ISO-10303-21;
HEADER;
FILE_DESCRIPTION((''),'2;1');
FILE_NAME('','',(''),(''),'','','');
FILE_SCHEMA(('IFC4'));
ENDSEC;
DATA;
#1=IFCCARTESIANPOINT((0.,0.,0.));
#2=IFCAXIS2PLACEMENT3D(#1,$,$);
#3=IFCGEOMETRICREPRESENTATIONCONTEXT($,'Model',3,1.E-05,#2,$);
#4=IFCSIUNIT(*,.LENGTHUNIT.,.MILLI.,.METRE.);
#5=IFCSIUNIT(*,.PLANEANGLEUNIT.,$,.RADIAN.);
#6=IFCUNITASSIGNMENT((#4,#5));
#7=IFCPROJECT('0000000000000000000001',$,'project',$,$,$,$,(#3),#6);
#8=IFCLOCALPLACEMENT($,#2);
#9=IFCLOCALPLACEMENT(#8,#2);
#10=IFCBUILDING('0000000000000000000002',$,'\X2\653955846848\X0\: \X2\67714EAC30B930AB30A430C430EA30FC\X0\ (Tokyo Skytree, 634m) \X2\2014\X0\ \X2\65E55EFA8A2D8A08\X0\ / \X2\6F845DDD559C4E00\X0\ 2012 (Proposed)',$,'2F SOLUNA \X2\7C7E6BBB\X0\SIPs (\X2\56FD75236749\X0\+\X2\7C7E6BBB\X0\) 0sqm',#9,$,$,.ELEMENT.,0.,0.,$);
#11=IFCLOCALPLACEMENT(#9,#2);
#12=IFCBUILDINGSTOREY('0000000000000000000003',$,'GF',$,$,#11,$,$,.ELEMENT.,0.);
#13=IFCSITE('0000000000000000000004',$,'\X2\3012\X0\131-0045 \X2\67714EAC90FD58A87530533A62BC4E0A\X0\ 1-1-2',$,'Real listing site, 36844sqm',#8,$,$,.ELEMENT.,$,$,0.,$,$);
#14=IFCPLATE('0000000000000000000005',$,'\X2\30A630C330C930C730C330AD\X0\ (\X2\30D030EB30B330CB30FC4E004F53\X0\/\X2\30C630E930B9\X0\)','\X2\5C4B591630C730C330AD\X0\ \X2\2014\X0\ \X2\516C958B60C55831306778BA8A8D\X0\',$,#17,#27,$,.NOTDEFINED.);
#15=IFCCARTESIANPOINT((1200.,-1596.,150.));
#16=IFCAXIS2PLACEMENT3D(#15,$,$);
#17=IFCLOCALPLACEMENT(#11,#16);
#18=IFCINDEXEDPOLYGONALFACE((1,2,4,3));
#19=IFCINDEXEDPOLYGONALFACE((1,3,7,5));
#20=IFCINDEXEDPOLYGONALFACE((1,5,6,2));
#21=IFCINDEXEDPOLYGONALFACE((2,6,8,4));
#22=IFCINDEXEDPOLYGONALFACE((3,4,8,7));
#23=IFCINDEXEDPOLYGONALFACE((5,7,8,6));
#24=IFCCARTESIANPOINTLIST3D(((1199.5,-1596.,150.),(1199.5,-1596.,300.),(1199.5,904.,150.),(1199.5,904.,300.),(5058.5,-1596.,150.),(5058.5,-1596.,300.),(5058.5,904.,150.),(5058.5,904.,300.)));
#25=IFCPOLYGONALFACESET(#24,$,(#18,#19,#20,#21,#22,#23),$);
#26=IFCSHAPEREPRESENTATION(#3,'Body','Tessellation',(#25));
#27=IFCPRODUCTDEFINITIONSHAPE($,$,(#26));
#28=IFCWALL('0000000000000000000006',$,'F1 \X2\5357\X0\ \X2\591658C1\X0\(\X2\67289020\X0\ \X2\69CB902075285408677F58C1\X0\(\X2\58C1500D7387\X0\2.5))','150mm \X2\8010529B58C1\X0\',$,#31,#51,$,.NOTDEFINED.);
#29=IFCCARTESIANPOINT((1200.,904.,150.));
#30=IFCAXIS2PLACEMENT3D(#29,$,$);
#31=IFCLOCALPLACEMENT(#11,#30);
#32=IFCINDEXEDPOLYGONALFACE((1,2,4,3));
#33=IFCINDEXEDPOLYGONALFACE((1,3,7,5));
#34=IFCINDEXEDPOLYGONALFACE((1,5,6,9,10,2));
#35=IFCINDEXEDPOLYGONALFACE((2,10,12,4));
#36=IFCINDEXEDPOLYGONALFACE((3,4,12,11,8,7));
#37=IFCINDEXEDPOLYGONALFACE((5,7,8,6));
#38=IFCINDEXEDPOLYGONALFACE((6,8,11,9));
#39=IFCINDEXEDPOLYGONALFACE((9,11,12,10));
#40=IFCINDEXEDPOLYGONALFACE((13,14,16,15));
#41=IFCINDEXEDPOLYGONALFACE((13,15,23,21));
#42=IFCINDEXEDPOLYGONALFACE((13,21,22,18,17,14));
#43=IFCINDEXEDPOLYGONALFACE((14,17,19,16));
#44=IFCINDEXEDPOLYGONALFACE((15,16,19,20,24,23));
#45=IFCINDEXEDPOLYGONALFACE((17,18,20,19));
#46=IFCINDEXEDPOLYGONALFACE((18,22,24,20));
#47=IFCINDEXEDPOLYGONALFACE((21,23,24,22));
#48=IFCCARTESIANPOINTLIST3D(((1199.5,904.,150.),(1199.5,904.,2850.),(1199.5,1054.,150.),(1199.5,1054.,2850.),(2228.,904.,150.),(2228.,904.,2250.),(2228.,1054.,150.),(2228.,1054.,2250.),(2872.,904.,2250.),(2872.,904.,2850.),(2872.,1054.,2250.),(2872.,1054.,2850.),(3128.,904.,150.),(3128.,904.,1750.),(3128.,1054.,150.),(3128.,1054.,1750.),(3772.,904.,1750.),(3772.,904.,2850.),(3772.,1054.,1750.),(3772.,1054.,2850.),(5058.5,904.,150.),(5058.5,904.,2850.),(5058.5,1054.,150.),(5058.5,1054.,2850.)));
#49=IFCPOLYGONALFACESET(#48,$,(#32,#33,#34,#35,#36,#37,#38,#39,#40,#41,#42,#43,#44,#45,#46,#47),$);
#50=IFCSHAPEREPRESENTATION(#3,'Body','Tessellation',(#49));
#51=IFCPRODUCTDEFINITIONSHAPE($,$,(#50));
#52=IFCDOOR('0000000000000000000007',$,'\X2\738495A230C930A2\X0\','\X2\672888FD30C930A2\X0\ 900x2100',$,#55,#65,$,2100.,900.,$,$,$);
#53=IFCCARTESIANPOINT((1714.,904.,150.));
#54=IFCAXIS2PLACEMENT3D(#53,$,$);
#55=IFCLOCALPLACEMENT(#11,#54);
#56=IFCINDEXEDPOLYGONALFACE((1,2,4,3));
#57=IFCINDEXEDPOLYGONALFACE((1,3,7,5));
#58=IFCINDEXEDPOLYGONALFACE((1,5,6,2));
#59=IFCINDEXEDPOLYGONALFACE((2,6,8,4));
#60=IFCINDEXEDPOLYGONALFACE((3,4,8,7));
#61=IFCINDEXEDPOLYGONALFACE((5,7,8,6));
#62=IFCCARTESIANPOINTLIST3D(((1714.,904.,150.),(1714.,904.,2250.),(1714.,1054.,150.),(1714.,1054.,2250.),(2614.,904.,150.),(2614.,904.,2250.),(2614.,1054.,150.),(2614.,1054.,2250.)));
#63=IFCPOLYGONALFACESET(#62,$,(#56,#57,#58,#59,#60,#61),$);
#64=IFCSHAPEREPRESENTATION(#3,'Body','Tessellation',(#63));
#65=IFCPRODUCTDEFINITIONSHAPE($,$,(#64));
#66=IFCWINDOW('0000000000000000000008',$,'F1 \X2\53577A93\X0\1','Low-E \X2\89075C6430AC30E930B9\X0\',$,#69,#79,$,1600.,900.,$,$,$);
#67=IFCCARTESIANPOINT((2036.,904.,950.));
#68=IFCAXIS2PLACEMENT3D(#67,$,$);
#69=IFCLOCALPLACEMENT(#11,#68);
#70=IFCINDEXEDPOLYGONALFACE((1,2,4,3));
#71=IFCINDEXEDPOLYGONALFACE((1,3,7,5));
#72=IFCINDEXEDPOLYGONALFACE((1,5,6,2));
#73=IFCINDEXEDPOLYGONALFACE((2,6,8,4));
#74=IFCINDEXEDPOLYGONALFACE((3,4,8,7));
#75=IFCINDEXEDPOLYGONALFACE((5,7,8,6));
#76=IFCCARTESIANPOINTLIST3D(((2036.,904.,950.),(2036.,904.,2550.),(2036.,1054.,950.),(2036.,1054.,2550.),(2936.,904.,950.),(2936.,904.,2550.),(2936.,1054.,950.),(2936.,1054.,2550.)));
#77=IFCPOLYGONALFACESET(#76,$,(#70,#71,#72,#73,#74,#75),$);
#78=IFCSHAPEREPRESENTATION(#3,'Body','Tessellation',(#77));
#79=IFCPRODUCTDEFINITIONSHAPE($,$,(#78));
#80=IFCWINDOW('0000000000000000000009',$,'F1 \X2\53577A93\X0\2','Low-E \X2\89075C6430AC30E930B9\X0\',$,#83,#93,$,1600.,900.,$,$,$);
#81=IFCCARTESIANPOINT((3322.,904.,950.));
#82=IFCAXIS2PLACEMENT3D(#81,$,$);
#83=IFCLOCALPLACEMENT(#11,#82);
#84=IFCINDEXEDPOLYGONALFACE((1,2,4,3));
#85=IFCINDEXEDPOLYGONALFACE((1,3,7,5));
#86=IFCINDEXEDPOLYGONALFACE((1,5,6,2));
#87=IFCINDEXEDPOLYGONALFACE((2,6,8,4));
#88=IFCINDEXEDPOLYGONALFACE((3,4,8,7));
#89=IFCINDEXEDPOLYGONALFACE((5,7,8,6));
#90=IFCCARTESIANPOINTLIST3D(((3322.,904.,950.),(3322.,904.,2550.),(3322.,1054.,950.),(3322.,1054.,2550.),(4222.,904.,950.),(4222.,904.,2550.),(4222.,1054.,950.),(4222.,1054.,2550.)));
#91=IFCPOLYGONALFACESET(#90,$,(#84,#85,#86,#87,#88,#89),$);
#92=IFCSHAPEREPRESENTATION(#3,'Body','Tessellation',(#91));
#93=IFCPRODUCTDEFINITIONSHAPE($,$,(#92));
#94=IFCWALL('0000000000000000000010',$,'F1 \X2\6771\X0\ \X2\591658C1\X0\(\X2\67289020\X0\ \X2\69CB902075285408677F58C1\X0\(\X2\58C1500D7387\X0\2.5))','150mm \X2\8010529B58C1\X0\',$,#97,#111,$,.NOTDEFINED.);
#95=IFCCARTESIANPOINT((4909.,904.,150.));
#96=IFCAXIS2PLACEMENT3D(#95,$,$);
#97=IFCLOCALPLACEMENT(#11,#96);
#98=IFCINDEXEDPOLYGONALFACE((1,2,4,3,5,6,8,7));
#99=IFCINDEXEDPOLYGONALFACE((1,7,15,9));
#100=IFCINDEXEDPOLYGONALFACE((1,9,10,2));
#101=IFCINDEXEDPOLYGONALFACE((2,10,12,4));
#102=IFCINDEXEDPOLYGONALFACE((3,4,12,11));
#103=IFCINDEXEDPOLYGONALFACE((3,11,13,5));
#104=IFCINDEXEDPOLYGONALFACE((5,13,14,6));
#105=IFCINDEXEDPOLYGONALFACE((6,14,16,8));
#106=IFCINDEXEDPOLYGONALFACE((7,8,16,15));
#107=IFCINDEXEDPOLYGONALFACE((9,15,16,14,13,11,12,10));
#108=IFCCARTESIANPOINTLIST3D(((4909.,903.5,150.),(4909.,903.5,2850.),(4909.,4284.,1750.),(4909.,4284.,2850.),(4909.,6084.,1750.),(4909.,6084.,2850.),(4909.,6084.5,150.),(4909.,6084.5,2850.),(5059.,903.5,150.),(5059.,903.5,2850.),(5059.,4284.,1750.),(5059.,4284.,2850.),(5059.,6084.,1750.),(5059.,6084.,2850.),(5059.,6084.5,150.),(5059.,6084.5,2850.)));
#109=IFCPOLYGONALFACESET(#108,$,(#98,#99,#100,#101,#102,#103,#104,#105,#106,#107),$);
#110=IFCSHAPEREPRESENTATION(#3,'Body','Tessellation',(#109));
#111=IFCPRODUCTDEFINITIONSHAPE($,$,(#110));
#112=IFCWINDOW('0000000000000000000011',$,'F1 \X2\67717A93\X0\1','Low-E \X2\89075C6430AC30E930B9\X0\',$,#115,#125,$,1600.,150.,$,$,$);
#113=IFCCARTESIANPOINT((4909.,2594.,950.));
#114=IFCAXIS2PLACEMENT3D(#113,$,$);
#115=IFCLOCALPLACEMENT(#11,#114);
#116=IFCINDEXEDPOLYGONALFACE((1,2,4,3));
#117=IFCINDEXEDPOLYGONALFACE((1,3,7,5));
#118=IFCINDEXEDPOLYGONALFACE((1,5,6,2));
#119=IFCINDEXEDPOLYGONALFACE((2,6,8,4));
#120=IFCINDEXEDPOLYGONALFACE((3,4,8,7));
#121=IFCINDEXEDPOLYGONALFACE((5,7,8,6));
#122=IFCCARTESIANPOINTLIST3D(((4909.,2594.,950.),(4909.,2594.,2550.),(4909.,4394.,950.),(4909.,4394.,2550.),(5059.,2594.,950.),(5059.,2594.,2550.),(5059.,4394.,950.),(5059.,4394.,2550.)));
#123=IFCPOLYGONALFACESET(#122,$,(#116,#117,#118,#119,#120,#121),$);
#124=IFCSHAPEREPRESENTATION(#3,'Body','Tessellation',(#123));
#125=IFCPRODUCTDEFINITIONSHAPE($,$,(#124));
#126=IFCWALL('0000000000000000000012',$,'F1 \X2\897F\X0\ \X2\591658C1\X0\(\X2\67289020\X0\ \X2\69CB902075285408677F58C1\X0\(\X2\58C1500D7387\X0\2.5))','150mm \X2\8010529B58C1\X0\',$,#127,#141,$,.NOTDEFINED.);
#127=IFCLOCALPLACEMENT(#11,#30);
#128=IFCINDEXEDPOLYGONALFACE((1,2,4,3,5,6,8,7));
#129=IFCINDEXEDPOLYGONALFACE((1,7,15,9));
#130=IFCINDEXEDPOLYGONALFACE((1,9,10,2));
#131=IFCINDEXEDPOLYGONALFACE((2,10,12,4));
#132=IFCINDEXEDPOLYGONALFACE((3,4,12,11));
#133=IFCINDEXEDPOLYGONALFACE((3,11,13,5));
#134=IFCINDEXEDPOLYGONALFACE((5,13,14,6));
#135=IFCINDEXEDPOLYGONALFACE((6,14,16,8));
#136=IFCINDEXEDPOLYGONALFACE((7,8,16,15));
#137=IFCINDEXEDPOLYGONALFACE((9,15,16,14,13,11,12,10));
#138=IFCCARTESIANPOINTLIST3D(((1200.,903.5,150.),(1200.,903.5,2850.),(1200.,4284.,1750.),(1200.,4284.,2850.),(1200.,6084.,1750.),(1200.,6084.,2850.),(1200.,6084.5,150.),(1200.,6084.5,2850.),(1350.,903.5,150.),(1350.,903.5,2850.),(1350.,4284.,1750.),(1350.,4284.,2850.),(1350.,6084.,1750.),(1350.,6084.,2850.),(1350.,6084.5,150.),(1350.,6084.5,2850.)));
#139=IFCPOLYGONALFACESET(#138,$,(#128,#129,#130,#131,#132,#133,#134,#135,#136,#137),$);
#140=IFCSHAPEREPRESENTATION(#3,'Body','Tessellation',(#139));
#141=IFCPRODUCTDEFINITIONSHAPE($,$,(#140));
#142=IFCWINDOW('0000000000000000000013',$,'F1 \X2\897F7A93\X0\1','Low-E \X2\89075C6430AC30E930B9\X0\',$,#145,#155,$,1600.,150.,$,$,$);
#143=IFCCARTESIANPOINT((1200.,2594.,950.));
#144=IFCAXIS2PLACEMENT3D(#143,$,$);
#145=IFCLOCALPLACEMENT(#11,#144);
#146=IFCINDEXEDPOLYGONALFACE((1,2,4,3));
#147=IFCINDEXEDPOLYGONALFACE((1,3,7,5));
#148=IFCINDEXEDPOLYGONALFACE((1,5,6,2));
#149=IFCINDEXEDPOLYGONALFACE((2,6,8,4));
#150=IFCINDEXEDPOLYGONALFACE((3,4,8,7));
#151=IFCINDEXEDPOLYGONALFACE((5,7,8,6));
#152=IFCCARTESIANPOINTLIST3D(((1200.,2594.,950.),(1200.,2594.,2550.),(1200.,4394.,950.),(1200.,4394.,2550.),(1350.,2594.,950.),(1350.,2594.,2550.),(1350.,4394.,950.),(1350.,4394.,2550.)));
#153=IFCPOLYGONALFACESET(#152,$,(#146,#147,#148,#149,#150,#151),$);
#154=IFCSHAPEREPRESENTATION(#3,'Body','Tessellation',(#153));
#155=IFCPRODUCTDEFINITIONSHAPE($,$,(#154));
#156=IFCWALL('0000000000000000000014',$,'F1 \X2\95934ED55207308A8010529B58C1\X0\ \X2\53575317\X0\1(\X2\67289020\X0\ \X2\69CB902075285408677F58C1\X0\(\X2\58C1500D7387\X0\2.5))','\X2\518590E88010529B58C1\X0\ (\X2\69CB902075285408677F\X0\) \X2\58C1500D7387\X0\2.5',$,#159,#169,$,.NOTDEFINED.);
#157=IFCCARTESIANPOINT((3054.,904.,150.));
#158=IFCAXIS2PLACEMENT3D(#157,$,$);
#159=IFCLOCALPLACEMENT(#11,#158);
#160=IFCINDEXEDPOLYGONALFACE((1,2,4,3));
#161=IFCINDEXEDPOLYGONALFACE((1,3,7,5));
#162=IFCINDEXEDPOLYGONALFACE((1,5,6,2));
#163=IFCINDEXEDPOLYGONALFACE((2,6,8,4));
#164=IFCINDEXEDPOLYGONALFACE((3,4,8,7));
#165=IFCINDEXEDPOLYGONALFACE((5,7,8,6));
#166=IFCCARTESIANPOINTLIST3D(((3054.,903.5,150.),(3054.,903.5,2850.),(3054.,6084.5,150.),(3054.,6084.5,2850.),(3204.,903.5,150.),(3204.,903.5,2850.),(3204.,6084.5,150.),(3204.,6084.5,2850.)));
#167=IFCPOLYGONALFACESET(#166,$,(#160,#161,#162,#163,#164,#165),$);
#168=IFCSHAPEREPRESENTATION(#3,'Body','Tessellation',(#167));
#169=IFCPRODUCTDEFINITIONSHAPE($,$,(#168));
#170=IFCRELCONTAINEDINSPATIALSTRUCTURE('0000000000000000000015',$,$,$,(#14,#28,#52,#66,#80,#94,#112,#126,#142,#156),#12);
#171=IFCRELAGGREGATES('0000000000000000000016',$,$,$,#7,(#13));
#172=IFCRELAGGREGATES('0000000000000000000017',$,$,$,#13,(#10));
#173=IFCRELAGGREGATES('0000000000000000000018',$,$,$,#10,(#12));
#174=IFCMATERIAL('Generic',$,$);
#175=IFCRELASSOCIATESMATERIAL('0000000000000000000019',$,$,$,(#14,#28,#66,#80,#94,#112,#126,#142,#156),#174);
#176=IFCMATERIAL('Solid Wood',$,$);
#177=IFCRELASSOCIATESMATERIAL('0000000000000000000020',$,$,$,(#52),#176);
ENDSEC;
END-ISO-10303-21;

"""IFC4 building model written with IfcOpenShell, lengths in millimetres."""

from ifc_helpers import new_model, si_unit, frame, frame_2d, origin, place, context, project, spatial, rectangle, extrude, material, element, fill, save


model = new_model("IFC4")

# Units and contexts
model_context = context("Model", 3, precision=1e-05, world=origin())
ifc_project = project(units=[si_unit("LENGTHUNIT", "METRE", prefix="MILLI"), si_unit("PLANEANGLEUNIT", "RADIAN")], contexts=[model_context])

# Site, building, storey
site_placement = place(None, origin())
site = spatial("IfcSite", under=ifc_project, at=site_placement, Name="〒131-0045 東京都墨田区押上 1-1-2", ObjectType="Real listing site, 36844sqm", CompositionType="ELEMENT", RefElevation=0.0)
building_placement = place(site_placement, origin())
building = spatial("IfcBuilding", under=site, at=building_placement, Name="改善案: 東京スカイツリー (Tokyo Skytree, 634m) — 日建設計 / 澄川喜一 2012 (Proposed)", ObjectType="2F SOLUNA 籾殻SIPs (国産杉+籾殻) 0sqm", CompositionType="ELEMENT", ElevationOfRefHeight=0.0, ElevationOfTerrain=0.0)
storey_placement = place(building_placement, origin())
storey = spatial("IfcBuildingStorey", under=building, at=storey_placement, Name="GF", CompositionType="ELEMENT", Elevation=0.0)

# Shared definitions
ifc_material_1 = material(Name="Generic")

# Plate
plate_placement = place(storey_placement, frame((1200.0, -1596.0, 150.0)))
element("IfcPlate", 1, at=plate_placement, inside=storey, material=ifc_material_1, Name="ウッドデッキ (バルコニー一体/テラス)", Description="屋外デッキ — 公開情報で確認", PredefinedType="NOTDEFINED", context=model_context, shape_type="SweptSolid", body=[
    extrude(rectangle(XDim=3859.0, YDim=2500.0, at=frame_2d((1929.0, 1250.0))), frame((1200.0, -1596.0, 150.0)), (0.0, 0.0, 1.0), 150.0),
])

# Wall, openings, door, windows
wall_1_placement = place(storey_placement, frame((1200.0, 904.0, 150.0)))
wall_1 = element("IfcWall", 2, at=wall_1_placement, inside=storey, material=ifc_material_1, Name="F1 南 外壁(木造 構造用合板壁(壁倍率2.5))", Description="150mm 耐力壁", PredefinedType="NOTDEFINED", context=model_context, shape_type="SweptSolid", body=[
    extrude(rectangle(XDim=3859.0, YDim=150.0, at=frame_2d((1929.0, 75.0))), frame((1200.0, 904.0, 150.0)), (0.0, 0.0, 1.0), 2700.0),
])
opening_1_placement = place(storey_placement, frame((1714.0, 904.0, 150.0)))
opening_1 = element("IfcOpeningElement", 3, at=opening_1_placement, cuts=wall_1, PredefinedType="NOTDEFINED", context=model_context, shape_type="SweptSolid", body=[
    extrude(rectangle(XDim=900.0, YDim=150.0, at=frame_2d((450.0, 75.0))), frame((1714.0, 904.0, 150.0)), (0.0, 0.0, 1.0), 2100.0),
])
opening_2_placement = place(storey_placement, frame((2036.0, 904.0, 950.0)))
opening_2 = element("IfcOpeningElement", 4, at=opening_2_placement, cuts=wall_1, PredefinedType="NOTDEFINED", context=model_context, shape_type="SweptSolid", body=[
    extrude(rectangle(XDim=900.0, YDim=150.0, at=frame_2d((450.0, 75.0))), frame((2036.0, 904.0, 950.0)), (0.0, 0.0, 1.0), 1600.0),
])
opening_3_placement = place(storey_placement, frame((3322.0, 904.0, 950.0)))
opening_3 = element("IfcOpeningElement", 5, at=opening_3_placement, cuts=wall_1, PredefinedType="NOTDEFINED", context=model_context, shape_type="SweptSolid", body=[
    extrude(rectangle(XDim=900.0, YDim=150.0, at=frame_2d((450.0, 75.0))), frame((3322.0, 904.0, 950.0)), (0.0, 0.0, 1.0), 1600.0),
])
ifc_material_2 = material(Name="Solid Wood")
door_placement = place(storey_placement, frame((1714.0, 904.0, 150.0)))
door = element("IfcDoor", 6, at=door_placement, inside=storey, material=ifc_material_2, Name="玄関ドア", Description="木製ドア 900x2100", OverallHeight=2100.0, OverallWidth=900.0, context=model_context, shape_type="SweptSolid", body=[
    extrude(rectangle(XDim=900.0, YDim=150.0, at=frame_2d((450.0, 75.0))), frame((1714.0, 904.0, 150.0)), (0.0, 0.0, 1.0), 2100.0),
])
fill(opening_1, door)
window_1_placement = place(storey_placement, frame((2036.0, 904.0, 950.0)))
window_1 = element("IfcWindow", 7, at=window_1_placement, inside=storey, material=ifc_material_1, Name="F1 南窓1", Description="Low-E 複層ガラス", OverallHeight=1600.0, OverallWidth=900.0, context=model_context, shape_type="SweptSolid", body=[
    extrude(rectangle(XDim=900.0, YDim=150.0, at=frame_2d((450.0, 75.0))), frame((2036.0, 904.0, 950.0)), (0.0, 0.0, 1.0), 1600.0),
])
fill(opening_2, window_1)
window_2_placement = place(storey_placement, frame((3322.0, 904.0, 950.0)))
window_2 = element("IfcWindow", 8, at=window_2_placement, inside=storey, material=ifc_material_1, Name="F1 南窓2", Description="Low-E 複層ガラス", OverallHeight=1600.0, OverallWidth=900.0, context=model_context, shape_type="SweptSolid", body=[
    extrude(rectangle(XDim=900.0, YDim=150.0, at=frame_2d((450.0, 75.0))), frame((3322.0, 904.0, 950.0)), (0.0, 0.0, 1.0), 1600.0),
])
fill(opening_3, window_2)

# Walls, openings, windows
wall_2_placement = place(storey_placement, frame((4909.0, 904.0, 150.0)))
wall_2 = element("IfcWall", 9, at=wall_2_placement, inside=storey, material=ifc_material_1, Name="F1 東 外壁(木造 構造用合板壁(壁倍率2.5))", Description="150mm 耐力壁", PredefinedType="NOTDEFINED", context=model_context, shape_type="SweptSolid", body=[
    extrude(rectangle(XDim=150.0, YDim=5181.0, at=frame_2d((75.0, 2590.0))), frame((4909.0, 904.0, 150.0)), (0.0, 0.0, 1.0), 2700.0),
])
opening_4_placement = place(storey_placement, frame((4909.0, 2594.0, 950.0)))
opening_4 = element("IfcOpeningElement", 10, at=opening_4_placement, cuts=wall_2, PredefinedType="NOTDEFINED", context=model_context, shape_type="SweptSolid", body=[
    extrude(rectangle(XDim=150.0, YDim=1800.0, at=frame_2d((75.0, 900.0))), frame((4909.0, 2594.0, 950.0)), (0.0, 0.0, 1.0), 1600.0),
])
window_3_placement = place(storey_placement, frame((4909.0, 2594.0, 950.0)))
window_3 = element("IfcWindow", 11, at=window_3_placement, inside=storey, material=ifc_material_1, Name="F1 東窓1", Description="Low-E 複層ガラス", OverallHeight=1600.0, OverallWidth=150.0, context=model_context, shape_type="SweptSolid", body=[
    extrude(rectangle(XDim=150.0, YDim=1800.0, at=frame_2d((75.0, 900.0))), frame((4909.0, 2594.0, 950.0)), (0.0, 0.0, 1.0), 1600.0),
])
fill(opening_4, window_3)
wall_3_placement = place(storey_placement, frame((1200.0, 904.0, 150.0)))
wall_3 = element("IfcWall", 12, at=wall_3_placement, inside=storey, material=ifc_material_1, Name="F1 西 外壁(木造 構造用合板壁(壁倍率2.5))", Description="150mm 耐力壁", PredefinedType="NOTDEFINED", context=model_context, shape_type="SweptSolid", body=[
    extrude(rectangle(XDim=150.0, YDim=5181.0, at=frame_2d((75.0, 2590.0))), frame((1200.0, 904.0, 150.0)), (0.0, 0.0, 1.0), 2700.0),
])
opening_5_placement = place(storey_placement, frame((1200.0, 2594.0, 950.0)))
opening_5 = element("IfcOpeningElement", 13, at=opening_5_placement, cuts=wall_3, PredefinedType="NOTDEFINED", context=model_context, shape_type="SweptSolid", body=[
    extrude(rectangle(XDim=150.0, YDim=1800.0, at=frame_2d((75.0, 900.0))), frame((1200.0, 2594.0, 950.0)), (0.0, 0.0, 1.0), 1600.0),
])
window_4_placement = place(storey_placement, frame((1200.0, 2594.0, 950.0)))
window_4 = element("IfcWindow", 14, at=window_4_placement, inside=storey, material=ifc_material_1, Name="F1 西窓1", Description="Low-E 複層ガラス", OverallHeight=1600.0, OverallWidth=150.0, context=model_context, shape_type="SweptSolid", body=[
    extrude(rectangle(XDim=150.0, YDim=1800.0, at=frame_2d((75.0, 900.0))), frame((1200.0, 2594.0, 950.0)), (0.0, 0.0, 1.0), 1600.0),
])
fill(opening_5, window_4)

# Wall
wall_4_placement = place(storey_placement, frame((3054.0, 904.0, 150.0)))
element("IfcWall", 15, at=wall_4_placement, inside=storey, material=ifc_material_1, Name="F1 間仕切り耐力壁 南北1(木造 構造用合板壁(壁倍率2.5))", Description="内部耐力壁 (構造用合板) 壁倍率2.5", PredefinedType="NOTDEFINED", context=model_context, shape_type="SweptSolid", body=[
    extrude(rectangle(XDim=150.0, YDim=5181.0, at=frame_2d((75.0, 2590.0))), frame((3054.0, 904.0, 150.0)), (0.0, 0.0, 1.0), 2700.0),
])

save(model, "model.ifc")
